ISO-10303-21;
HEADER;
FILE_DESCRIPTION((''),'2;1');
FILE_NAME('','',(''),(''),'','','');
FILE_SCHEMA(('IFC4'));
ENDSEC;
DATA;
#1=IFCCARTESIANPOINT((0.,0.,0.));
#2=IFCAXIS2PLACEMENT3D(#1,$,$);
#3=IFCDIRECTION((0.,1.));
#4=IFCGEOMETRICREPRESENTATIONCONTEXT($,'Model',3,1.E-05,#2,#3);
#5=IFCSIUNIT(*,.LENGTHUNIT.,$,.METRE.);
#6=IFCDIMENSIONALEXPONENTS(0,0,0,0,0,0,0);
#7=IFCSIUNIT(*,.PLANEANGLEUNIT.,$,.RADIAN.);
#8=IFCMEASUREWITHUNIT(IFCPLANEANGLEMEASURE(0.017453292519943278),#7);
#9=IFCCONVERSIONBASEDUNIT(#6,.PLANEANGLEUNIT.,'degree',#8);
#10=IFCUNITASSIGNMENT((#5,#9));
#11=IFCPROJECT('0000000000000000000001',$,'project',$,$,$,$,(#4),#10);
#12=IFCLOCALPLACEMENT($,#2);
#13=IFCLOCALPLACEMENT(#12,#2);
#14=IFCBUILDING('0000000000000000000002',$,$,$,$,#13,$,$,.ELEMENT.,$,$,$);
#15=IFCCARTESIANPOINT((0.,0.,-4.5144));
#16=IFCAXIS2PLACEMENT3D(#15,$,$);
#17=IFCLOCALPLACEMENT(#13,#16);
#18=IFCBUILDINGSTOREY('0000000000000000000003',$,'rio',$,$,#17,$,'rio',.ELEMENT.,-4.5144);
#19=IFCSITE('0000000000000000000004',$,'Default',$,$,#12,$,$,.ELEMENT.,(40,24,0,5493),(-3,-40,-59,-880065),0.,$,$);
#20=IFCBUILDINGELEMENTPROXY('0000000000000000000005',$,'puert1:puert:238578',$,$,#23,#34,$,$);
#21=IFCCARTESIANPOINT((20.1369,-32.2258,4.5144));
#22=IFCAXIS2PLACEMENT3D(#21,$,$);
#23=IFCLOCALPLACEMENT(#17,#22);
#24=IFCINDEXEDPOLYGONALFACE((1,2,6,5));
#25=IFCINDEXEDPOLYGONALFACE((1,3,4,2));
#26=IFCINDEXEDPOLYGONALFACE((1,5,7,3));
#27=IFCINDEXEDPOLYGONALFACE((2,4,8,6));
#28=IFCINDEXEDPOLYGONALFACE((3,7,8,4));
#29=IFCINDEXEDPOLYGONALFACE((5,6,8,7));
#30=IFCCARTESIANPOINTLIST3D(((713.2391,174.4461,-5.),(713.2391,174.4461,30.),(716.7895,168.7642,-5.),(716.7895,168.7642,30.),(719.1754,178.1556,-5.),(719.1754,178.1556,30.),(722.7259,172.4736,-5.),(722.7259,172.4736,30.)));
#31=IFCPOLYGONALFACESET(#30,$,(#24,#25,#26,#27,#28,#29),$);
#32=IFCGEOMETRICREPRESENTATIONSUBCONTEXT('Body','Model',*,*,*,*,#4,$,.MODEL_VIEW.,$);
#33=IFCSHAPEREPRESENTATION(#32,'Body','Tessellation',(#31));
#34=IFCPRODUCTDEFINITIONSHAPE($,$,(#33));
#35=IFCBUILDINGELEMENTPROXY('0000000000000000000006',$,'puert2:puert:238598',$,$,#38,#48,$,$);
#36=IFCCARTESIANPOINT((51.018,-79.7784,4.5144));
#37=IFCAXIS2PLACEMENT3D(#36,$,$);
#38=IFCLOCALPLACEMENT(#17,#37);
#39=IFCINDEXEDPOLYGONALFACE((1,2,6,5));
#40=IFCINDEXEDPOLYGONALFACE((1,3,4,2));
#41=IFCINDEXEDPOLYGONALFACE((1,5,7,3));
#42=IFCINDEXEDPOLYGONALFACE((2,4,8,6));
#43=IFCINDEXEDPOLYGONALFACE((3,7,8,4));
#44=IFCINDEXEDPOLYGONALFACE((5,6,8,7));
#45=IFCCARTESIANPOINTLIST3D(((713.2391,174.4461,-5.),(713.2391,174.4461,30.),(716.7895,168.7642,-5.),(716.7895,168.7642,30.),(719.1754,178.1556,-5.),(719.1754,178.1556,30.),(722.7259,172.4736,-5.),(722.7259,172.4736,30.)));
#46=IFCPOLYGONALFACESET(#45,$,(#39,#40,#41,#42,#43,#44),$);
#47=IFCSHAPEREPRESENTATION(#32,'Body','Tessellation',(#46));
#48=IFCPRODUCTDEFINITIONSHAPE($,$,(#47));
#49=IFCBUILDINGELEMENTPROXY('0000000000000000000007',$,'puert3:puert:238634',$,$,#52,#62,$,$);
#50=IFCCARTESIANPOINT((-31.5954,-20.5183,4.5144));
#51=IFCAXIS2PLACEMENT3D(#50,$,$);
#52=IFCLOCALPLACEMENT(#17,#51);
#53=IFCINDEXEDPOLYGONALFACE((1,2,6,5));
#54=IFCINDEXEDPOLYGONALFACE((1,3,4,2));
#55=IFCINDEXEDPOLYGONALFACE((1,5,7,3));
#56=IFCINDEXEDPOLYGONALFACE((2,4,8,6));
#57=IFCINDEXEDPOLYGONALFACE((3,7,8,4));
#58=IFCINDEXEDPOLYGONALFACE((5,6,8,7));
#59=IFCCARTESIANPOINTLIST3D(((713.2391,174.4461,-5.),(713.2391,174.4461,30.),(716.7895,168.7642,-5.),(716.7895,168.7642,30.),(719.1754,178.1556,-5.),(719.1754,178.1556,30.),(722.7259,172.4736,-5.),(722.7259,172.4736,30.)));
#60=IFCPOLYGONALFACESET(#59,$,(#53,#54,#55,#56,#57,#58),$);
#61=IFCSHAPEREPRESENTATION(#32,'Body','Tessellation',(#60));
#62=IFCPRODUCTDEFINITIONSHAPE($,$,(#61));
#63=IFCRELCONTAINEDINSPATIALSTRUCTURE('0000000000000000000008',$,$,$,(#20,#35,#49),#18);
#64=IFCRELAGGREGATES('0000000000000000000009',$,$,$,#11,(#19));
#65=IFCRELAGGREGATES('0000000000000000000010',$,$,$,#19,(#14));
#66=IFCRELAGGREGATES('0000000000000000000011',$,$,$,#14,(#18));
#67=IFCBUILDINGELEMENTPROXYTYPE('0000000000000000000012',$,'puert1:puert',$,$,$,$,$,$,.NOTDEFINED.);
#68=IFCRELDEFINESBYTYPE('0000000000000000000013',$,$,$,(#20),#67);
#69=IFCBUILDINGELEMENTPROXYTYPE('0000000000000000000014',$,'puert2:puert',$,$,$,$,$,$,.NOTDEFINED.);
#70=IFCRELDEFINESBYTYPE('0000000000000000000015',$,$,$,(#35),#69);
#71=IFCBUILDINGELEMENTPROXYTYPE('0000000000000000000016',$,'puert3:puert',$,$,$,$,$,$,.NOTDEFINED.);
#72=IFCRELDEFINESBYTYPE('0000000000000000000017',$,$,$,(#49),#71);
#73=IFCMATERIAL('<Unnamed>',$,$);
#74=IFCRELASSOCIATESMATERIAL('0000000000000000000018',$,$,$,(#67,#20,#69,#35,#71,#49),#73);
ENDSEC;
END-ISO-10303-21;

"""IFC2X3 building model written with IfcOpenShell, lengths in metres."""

from ifc_helpers import new_model, entity, si_unit, converted_unit, direction, frame, origin, origin_2d_with_axis, place, context, subcontext, project, spatial, rectangle, extrude, source, transform, mapped, material, type_object, type_shapes, element, save


model = new_model("IFC2X3")

# Units and contexts
model_context = context("Model", 3, precision=1e-05, world=origin(), true_north=direction((0.0, 1.0)))
body_context = subcontext(model_context, "Body", "Model", "MODEL_VIEW")
ifc_project = project(units=[si_unit("LENGTHUNIT", "METRE"), converted_unit("PLANEANGLEUNIT", "degree", entity("IfcPlaneAngleMeasure", 0.017453292519943278), si_unit("PLANEANGLEUNIT", "RADIAN"), dimensions=[0, 0, 0, 0, 0, 0, 0])], contexts=[model_context])

# Site, building, storey
site_placement = place(None, origin())
site = spatial("IfcSite", under=ifc_project, at=site_placement, Name="Default", CompositionType="ELEMENT", RefLatitude=(40, 24, 0, 5493), RefLongitude=(-3, -40, -59, -880065), RefElevation=0.0)
building_placement = place(site_placement, origin())
building = spatial("IfcBuilding", under=site, at=building_placement, CompositionType="ELEMENT")
storey_placement = place(building_placement, frame((0.0, 0.0, -4.5144)))
storey = spatial("IfcBuildingStorey", under=building, at=storey_placement, Name="rio", LongName="rio", CompositionType="ELEMENT", Elevation=-4.5144)

# Building element proxies
ifc_material_1 = material(Name="<Unnamed>")
building_element_proxy_type_1 = type_object("IfcBuildingElementProxyType", Name="puert1:puert", PredefinedType="NOTDEFINED", material=ifc_material_1)
shared_shape_1 = source(origin(), body_context, "Body", "SweptSolid", [
    extrude(rectangle(XDim=7.0, YDim=6.7, at=origin_2d_with_axis()), frame((717.9825, 173.4599, -5.0), z_axis=(0.0, 0.0, 1.0), x_axis=(-0.848048, -0.529919, 0.0)), (0.0, 0.0, 1.0), 35.0),
])
type_shapes(building_element_proxy_type_1, [shared_shape_1])
proxy_1_placement = place(storey_placement, frame((20.1369, -32.2258, 4.5144)))
element("IfcBuildingElementProxy", 1, at=proxy_1_placement, inside=storey, type_object=building_element_proxy_type_1, material=ifc_material_1, Name="puert1:puert:238578", context=body_context, shape_type="MappedRepresentation", body=[
    mapped(shared_shape_1, transform((0.0, 0.0, 0.0), scale=1.0)),
])
building_element_proxy_type_2 = type_object("IfcBuildingElementProxyType", Name="puert2:puert", PredefinedType="NOTDEFINED", material=ifc_material_1)
shared_shape_2 = source(origin(), body_context, "Body", "SweptSolid", [
    extrude(rectangle(XDim=7.0, YDim=6.7, at=origin_2d_with_axis()), frame((717.9825, 173.4599, -5.0), z_axis=(0.0, 0.0, 1.0), x_axis=(-0.848048, -0.529919, 0.0)), (0.0, 0.0, 1.0), 35.0),
])
type_shapes(building_element_proxy_type_2, [shared_shape_2])
proxy_2_placement = place(storey_placement, frame((51.018, -79.7784, 4.5144)))
element("IfcBuildingElementProxy", 2, at=proxy_2_placement, inside=storey, type_object=building_element_proxy_type_2, material=ifc_material_1, Name="puert2:puert:238598", context=body_context, shape_type="MappedRepresentation", body=[
    mapped(shared_shape_2, transform((0.0, 0.0, 0.0), scale=1.0)),
])
building_element_proxy_type_3 = type_object("IfcBuildingElementProxyType", Name="puert3:puert", PredefinedType="NOTDEFINED", material=ifc_material_1)
shared_shape_3 = source(origin(), body_context, "Body", "SweptSolid", [
    extrude(rectangle(XDim=7.0, YDim=6.7, at=origin_2d_with_axis()), frame((717.9825, 173.4599, -5.0), z_axis=(0.0, 0.0, 1.0), x_axis=(-0.848048, -0.529919, 0.0)), (0.0, 0.0, 1.0), 35.0),
])
type_shapes(building_element_proxy_type_3, [shared_shape_3])
proxy_3_placement = place(storey_placement, frame((-31.5954, -20.5183, 4.5144)))
element("IfcBuildingElementProxy", 3, at=proxy_3_placement, inside=storey, type_object=building_element_proxy_type_3, material=ifc_material_1, Name="puert3:puert:238634", context=body_context, shape_type="MappedRepresentation", body=[
    mapped(shared_shape_3, transform((0.0, 0.0, 0.0), scale=1.0)),
])

save(model, "model.ifc")
